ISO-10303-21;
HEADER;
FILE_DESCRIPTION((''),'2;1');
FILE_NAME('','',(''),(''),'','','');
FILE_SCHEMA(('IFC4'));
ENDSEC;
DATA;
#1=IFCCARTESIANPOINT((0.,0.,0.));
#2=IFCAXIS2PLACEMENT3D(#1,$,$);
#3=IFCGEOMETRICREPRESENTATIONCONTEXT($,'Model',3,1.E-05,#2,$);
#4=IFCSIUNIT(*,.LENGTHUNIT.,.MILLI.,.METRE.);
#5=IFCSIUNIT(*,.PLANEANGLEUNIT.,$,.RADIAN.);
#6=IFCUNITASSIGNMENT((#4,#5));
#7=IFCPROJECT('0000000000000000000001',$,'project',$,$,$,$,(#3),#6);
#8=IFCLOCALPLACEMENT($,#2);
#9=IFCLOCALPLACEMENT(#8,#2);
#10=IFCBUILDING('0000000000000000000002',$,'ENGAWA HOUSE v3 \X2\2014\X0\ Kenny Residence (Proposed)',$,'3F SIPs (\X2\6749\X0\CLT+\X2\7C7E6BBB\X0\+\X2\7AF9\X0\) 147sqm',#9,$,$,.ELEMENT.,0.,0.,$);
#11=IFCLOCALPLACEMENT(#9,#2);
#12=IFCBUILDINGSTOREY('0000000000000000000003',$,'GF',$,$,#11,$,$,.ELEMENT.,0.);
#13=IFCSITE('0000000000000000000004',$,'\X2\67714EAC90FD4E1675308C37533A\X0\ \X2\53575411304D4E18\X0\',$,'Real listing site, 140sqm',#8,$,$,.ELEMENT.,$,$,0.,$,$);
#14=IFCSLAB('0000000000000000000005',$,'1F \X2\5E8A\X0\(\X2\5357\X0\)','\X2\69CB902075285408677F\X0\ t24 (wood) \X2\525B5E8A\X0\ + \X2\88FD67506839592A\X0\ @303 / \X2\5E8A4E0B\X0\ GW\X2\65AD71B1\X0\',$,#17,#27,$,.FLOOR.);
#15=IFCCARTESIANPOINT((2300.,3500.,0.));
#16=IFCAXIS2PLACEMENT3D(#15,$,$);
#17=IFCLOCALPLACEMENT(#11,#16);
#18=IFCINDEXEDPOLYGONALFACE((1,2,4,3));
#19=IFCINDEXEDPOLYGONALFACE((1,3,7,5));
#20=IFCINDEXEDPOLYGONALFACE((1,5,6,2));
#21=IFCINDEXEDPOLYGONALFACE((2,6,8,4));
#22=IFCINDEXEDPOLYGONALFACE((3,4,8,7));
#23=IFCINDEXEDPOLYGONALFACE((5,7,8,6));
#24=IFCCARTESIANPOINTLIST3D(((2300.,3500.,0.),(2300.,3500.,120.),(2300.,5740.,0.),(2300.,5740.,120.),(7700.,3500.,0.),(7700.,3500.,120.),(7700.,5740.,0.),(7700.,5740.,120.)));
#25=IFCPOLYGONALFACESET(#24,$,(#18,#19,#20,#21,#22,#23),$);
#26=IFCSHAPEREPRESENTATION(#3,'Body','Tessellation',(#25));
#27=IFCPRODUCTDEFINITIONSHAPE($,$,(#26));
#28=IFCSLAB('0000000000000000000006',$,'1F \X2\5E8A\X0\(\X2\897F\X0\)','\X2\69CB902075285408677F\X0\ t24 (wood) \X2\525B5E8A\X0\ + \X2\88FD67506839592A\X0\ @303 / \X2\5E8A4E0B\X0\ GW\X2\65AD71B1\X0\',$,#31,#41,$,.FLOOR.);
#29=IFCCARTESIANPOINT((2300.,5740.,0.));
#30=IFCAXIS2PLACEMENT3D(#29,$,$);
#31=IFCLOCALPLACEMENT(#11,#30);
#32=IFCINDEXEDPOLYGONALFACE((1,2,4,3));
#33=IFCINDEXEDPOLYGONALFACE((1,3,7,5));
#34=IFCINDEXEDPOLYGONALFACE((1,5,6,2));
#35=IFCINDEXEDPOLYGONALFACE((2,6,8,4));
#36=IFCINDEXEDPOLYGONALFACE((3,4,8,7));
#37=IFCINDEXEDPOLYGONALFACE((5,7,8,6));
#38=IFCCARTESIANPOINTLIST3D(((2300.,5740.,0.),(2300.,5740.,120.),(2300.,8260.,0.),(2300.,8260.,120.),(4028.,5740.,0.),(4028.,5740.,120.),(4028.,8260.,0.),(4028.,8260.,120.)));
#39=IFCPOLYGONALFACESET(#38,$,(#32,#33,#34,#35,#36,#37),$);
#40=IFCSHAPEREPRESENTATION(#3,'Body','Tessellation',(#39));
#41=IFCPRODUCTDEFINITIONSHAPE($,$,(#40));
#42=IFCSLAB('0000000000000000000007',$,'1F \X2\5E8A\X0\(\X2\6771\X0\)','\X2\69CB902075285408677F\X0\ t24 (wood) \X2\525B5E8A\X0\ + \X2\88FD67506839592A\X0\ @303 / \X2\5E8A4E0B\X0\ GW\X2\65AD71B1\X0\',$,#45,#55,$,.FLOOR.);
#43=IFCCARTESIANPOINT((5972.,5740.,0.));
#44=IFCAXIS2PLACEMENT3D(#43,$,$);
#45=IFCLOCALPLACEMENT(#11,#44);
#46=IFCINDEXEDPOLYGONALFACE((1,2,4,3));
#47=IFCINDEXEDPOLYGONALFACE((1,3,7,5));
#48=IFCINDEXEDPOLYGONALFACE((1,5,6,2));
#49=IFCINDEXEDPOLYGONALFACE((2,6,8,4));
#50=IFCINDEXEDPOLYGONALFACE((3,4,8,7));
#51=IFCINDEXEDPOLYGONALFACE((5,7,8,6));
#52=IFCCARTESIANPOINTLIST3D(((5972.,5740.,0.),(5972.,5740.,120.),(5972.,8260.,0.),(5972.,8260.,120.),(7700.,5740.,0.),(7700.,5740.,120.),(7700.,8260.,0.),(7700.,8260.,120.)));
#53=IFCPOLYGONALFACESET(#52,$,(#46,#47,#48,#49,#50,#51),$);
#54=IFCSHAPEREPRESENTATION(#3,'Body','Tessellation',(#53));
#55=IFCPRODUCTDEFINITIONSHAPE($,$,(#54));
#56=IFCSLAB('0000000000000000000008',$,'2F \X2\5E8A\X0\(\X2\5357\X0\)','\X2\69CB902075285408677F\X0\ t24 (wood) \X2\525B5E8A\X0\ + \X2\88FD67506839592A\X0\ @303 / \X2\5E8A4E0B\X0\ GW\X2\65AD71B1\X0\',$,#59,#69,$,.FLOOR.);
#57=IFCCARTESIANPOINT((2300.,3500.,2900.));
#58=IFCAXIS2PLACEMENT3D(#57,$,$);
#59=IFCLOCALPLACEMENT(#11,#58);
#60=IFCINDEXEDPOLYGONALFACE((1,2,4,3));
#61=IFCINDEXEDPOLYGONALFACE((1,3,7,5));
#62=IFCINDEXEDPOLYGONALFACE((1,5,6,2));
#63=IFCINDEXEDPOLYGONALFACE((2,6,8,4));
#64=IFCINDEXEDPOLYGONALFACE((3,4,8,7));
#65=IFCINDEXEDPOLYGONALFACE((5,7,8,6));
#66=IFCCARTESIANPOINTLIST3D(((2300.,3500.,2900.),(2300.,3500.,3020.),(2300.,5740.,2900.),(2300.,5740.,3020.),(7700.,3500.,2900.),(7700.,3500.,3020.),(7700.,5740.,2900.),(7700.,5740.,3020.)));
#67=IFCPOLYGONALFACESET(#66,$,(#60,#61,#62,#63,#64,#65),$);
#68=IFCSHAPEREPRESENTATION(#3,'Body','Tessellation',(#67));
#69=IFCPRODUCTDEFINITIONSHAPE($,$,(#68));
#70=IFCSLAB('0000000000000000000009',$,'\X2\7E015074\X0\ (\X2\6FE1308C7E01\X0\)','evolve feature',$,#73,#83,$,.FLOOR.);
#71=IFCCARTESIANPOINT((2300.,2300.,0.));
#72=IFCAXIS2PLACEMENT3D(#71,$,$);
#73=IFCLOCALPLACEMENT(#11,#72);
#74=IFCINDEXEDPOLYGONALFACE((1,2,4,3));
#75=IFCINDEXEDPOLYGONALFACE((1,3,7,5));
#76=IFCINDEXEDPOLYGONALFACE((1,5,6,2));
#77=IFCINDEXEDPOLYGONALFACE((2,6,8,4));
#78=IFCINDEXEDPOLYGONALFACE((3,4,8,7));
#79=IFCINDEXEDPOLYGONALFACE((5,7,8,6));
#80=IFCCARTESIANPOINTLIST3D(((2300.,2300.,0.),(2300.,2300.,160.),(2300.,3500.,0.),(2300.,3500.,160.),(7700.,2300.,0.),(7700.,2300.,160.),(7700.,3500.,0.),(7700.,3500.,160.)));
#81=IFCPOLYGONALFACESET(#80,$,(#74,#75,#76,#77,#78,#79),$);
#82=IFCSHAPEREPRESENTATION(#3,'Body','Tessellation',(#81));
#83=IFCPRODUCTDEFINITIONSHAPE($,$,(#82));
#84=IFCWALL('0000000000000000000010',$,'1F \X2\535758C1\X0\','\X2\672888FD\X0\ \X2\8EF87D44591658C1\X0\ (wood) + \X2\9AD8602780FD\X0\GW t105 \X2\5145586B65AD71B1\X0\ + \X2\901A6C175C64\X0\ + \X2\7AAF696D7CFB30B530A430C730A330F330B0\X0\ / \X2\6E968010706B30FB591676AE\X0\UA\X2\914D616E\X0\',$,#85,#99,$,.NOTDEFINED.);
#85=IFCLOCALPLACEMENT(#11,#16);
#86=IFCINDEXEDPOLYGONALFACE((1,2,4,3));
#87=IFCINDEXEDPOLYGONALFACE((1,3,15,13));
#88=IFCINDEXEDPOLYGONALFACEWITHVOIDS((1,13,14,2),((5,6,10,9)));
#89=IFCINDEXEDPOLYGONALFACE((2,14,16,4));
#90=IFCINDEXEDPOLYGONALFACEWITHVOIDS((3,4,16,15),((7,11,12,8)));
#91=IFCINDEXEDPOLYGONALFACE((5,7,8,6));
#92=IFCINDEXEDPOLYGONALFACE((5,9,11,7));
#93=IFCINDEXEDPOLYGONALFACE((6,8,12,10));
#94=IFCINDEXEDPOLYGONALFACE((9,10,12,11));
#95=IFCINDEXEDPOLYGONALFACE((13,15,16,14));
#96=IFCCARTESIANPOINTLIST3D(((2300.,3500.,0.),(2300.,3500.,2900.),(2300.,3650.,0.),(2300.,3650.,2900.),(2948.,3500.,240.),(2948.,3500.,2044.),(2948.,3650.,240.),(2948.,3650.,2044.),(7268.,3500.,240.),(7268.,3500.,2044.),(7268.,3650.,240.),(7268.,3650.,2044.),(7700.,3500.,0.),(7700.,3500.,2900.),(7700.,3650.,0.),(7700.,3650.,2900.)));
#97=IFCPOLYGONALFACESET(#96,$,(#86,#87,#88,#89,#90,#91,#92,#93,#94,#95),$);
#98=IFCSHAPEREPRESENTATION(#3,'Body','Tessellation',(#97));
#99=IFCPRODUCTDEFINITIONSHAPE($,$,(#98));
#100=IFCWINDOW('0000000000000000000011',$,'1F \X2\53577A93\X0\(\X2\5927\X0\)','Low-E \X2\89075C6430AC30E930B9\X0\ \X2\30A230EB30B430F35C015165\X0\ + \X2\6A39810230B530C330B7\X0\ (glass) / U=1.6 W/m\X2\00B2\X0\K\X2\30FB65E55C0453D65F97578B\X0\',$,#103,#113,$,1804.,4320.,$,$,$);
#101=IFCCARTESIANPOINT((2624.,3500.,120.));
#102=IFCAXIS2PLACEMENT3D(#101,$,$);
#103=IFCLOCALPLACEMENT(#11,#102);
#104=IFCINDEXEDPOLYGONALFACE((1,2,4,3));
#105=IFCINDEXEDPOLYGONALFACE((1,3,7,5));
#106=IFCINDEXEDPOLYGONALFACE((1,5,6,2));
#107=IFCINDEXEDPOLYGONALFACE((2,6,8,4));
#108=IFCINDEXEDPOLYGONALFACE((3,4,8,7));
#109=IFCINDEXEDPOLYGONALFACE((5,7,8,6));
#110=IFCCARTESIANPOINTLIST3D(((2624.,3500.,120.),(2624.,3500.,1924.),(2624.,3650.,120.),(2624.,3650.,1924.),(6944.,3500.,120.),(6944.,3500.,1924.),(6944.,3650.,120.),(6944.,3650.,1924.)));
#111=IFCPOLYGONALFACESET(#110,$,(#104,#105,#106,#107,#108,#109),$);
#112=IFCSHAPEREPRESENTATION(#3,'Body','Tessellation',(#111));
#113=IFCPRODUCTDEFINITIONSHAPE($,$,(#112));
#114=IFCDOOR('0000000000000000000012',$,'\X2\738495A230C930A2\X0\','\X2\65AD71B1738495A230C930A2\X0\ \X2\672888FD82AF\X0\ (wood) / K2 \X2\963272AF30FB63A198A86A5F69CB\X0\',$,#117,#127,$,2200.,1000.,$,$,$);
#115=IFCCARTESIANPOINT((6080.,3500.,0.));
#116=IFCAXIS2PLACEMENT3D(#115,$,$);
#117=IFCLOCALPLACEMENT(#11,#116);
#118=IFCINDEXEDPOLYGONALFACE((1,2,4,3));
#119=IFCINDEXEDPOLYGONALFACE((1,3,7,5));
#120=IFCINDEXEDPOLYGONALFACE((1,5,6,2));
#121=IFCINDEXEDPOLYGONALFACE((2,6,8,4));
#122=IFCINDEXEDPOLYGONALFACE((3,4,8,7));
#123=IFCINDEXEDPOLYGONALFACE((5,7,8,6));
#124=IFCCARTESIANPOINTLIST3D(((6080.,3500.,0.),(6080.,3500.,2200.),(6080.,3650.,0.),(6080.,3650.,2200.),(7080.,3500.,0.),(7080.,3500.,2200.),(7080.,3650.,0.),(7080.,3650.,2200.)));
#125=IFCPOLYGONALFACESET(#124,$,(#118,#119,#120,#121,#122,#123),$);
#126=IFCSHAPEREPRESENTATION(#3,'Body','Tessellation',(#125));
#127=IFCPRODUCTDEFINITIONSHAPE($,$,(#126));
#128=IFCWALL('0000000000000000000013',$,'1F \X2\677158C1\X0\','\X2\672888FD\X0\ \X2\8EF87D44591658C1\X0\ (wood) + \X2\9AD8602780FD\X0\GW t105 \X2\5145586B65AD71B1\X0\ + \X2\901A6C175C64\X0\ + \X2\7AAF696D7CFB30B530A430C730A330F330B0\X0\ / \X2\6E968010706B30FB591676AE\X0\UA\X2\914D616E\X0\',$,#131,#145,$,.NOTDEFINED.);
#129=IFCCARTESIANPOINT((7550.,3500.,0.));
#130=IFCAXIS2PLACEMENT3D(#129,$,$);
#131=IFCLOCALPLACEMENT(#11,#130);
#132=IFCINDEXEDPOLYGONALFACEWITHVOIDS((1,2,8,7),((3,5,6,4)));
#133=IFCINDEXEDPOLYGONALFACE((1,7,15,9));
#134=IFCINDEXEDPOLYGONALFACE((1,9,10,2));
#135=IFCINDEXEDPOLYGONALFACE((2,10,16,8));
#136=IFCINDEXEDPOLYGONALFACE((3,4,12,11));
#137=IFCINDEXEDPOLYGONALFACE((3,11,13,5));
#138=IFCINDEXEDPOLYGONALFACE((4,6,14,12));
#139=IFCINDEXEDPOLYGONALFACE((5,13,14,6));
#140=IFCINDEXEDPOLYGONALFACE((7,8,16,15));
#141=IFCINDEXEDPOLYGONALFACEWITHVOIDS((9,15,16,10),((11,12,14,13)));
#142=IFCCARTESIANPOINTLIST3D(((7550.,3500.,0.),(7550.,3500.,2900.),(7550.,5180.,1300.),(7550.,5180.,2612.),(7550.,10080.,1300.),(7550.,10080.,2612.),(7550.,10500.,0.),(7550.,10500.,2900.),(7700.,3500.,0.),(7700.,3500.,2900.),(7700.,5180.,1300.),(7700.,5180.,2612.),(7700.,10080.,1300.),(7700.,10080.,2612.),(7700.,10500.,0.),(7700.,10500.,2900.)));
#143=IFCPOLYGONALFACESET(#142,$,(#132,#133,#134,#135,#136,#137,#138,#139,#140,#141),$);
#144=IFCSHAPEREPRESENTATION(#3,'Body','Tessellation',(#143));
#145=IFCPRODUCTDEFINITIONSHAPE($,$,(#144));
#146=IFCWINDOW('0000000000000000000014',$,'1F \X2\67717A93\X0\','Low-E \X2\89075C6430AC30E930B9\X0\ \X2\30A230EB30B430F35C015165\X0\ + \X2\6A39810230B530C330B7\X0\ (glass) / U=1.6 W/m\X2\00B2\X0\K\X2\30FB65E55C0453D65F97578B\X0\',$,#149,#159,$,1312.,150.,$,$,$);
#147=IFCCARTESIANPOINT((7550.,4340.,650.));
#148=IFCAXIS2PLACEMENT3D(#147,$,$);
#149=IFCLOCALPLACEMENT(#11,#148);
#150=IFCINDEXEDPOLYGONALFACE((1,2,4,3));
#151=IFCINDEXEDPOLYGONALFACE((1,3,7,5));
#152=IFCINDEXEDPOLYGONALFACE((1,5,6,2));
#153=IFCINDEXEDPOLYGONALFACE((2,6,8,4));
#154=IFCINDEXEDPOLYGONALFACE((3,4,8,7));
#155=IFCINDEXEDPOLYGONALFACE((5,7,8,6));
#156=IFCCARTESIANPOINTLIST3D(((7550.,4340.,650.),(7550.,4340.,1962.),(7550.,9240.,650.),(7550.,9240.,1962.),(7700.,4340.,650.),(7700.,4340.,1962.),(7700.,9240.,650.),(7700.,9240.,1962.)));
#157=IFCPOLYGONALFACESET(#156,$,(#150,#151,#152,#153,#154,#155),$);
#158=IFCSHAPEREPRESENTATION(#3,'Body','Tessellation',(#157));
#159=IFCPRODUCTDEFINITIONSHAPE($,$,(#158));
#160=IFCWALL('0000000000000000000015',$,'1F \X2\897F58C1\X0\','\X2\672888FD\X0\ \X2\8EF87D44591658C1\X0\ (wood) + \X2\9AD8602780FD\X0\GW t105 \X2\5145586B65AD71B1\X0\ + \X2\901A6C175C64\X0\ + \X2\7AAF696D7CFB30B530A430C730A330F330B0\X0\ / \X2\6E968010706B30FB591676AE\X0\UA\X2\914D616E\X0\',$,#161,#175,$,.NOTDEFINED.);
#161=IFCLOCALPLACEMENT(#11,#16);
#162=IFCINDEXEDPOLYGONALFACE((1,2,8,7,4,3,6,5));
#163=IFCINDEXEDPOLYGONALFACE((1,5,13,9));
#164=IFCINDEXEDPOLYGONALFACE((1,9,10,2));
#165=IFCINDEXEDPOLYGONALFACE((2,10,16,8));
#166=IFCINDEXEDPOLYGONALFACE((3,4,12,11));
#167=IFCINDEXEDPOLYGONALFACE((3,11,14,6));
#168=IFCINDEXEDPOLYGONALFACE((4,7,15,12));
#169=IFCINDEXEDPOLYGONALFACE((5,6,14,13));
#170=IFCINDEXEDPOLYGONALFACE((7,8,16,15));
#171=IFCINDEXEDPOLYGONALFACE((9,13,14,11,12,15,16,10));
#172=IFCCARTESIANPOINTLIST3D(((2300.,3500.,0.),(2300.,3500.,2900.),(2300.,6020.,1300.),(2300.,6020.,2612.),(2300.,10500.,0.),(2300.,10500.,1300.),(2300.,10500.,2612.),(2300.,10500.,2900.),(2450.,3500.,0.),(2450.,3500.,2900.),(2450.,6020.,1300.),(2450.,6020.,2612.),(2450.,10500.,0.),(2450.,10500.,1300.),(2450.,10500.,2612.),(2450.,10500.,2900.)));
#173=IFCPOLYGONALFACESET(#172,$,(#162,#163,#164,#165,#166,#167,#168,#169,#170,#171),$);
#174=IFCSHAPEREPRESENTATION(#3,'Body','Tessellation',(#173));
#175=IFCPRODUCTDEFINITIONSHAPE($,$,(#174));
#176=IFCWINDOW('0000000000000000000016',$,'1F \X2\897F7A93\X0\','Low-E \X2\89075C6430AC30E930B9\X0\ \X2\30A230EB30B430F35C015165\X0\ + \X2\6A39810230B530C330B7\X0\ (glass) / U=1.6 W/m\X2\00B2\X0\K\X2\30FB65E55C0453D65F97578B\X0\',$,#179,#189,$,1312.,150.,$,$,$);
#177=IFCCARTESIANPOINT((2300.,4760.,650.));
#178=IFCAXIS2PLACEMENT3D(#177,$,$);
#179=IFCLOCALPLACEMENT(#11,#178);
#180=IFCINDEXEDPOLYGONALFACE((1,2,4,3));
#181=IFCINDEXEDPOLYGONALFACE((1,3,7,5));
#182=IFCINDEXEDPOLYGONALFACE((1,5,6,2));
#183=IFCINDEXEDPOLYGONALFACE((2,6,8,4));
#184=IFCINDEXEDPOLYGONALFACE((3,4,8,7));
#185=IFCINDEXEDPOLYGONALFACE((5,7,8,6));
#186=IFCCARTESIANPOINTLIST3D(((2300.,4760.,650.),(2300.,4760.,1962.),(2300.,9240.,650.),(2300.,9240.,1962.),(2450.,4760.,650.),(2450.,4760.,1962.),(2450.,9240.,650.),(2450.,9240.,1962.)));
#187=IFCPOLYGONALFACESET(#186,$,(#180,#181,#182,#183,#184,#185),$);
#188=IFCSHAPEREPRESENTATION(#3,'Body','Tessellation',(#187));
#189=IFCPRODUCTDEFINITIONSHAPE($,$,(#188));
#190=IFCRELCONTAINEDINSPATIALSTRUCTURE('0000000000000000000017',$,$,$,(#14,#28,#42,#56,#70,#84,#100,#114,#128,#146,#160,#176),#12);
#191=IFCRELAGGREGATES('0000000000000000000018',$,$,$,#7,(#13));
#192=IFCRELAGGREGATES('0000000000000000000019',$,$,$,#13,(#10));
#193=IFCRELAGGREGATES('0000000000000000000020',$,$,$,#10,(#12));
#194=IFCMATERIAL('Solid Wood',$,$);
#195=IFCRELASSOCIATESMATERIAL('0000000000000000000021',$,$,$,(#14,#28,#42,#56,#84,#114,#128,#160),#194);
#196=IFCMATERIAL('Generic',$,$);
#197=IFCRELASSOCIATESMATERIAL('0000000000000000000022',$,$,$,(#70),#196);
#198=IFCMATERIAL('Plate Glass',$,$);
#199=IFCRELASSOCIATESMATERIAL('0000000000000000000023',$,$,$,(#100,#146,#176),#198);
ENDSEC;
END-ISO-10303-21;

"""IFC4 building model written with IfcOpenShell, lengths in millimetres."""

from ifc_helpers import new_model, si_unit, frame, frame_2d, origin, place, context, project, spatial, rectangle, extrude, material, element, fill, save


model = new_model("IFC4")

# Units and contexts
model_context = context("Model", 3, precision=1e-05, world=origin())
ifc_project = project(units=[si_unit("LENGTHUNIT", "METRE", prefix="MILLI"), si_unit("PLANEANGLEUNIT", "RADIAN")], contexts=[model_context])

# Site, building, storey
site_placement = place(None, origin())
site = spatial("IfcSite", under=ifc_project, at=site_placement, Name="東京都世田谷区 南向き丘", ObjectType="Real listing site, 140sqm", CompositionType="ELEMENT", RefElevation=0.0)
building_placement = place(site_placement, origin())
building = spatial("IfcBuilding", under=site, at=building_placement, Name="ENGAWA HOUSE v3 — Kenny Residence (Proposed)", ObjectType="3F SIPs (杉CLT+籾殻+竹) 147sqm", CompositionType="ELEMENT", ElevationOfRefHeight=0.0, ElevationOfTerrain=0.0)
storey_placement = place(building_placement, origin())
storey = spatial("IfcBuildingStorey", under=building, at=storey_placement, Name="GF", CompositionType="ELEMENT", Elevation=0.0)

# Slabs
ifc_material_1 = material(Name="Solid Wood")
slab_1_placement = place(storey_placement, frame((2300.0, 3500.0, 0.0)))
element("IfcSlab", 1, at=slab_1_placement, inside=storey, material=ifc_material_1, Name="1F 床(南)", Description="構造用合板 t24 (wood) 剛床 + 製材根太 @303 / 床下 GW断熱", PredefinedType="FLOOR", context=model_context, shape_type="SweptSolid", body=[
    extrude(rectangle(XDim=5400.0, YDim=2240.0, at=frame_2d((2700.0, 1120.0))), frame((2300.0, 3500.0, 0.0)), (0.0, 0.0, 1.0), 120.0),
])
slab_2_placement = place(storey_placement, frame((2300.0, 5740.0, 0.0)))
element("IfcSlab", 2, at=slab_2_placement, inside=storey, material=ifc_material_1, Name="1F 床(西)", Description="構造用合板 t24 (wood) 剛床 + 製材根太 @303 / 床下 GW断熱", PredefinedType="FLOOR", context=model_context, shape_type="SweptSolid", body=[
    extrude(rectangle(XDim=1728.0, YDim=2520.0, at=frame_2d((864.0, 1260.0))), frame((2300.0, 5740.0, 0.0)), (0.0, 0.0, 1.0), 120.0),
])
slab_3_placement = place(storey_placement, frame((5972.0, 5740.0, 0.0)))
element("IfcSlab", 3, at=slab_3_placement, inside=storey, material=ifc_material_1, Name="1F 床(東)", Description="構造用合板 t24 (wood) 剛床 + 製材根太 @303 / 床下 GW断熱", PredefinedType="FLOOR", context=model_context, shape_type="SweptSolid", body=[
    extrude(rectangle(XDim=1728.0, YDim=2520.0, at=frame_2d((864.0, 1260.0))), frame((5972.0, 5740.0, 0.0)), (0.0, 0.0, 1.0), 120.0),
])
slab_4_placement = place(storey_placement, frame((2300.0, 3500.0, 2900.0)))
element("IfcSlab", 4, at=slab_4_placement, inside=storey, material=ifc_material_1, Name="2F 床(南)", Description="構造用合板 t24 (wood) 剛床 + 製材根太 @303 / 床下 GW断熱", PredefinedType="FLOOR", context=model_context, shape_type="SweptSolid", body=[
    extrude(rectangle(XDim=5400.0, YDim=2240.0, at=frame_2d((2700.0, 1120.0))), frame((2300.0, 3500.0, 2900.0)), (0.0, 0.0, 1.0), 120.0),
])
ifc_material_2 = material(Name="Generic")
slab_5_placement = place(storey_placement, frame((2300.0, 2300.0, 0.0)))
element("IfcSlab", 5, at=slab_5_placement, inside=storey, material=ifc_material_2, Name="縁側 (濡れ縁)", Description="evolve feature", PredefinedType="FLOOR", context=model_context, shape_type="SweptSolid", body=[
    extrude(rectangle(XDim=5400.0, YDim=1200.0, at=frame_2d((2700.0, 600.0))), frame((2300.0, 2300.0, 0.0)), (0.0, 0.0, 1.0), 160.0),
])

# Wall, openings, window, door
wall_1_placement = place(storey_placement, frame((2300.0, 3500.0, 0.0)))
wall_1 = element("IfcWall", 6, at=wall_1_placement, inside=storey, material=ifc_material_1, Name="1F 南壁", Description="木製 軸組外壁 (wood) + 高性能GW t105 充填断熱 + 通気層 + 窯業系サイディング / 準耐火・外皮UA配慮", PredefinedType="NOTDEFINED", context=model_context, shape_type="SweptSolid", body=[
    extrude(rectangle(XDim=5400.0, YDim=150.0, at=frame_2d((2700.0, 75.0))), frame((2300.0, 3500.0, 0.0)), (0.0, 0.0, 1.0), 2900.0),
])
opening_1_placement = place(storey_placement, frame((2624.0, 3500.0, 120.0)))
opening_1 = element("IfcOpeningElement", 7, at=opening_1_placement, cuts=wall_1, PredefinedType="NOTDEFINED", context=model_context, shape_type="SweptSolid", body=[
    extrude(rectangle(XDim=4320.0, YDim=150.0, at=frame_2d((2160.0, 75.0))), frame((2624.0, 3500.0, 120.0)), (0.0, 0.0, 1.0), 1804.0),
])
opening_2_placement = place(storey_placement, frame((6080.0, 3500.0, 0.0)))
opening_2 = element("IfcOpeningElement", 8, at=opening_2_placement, cuts=wall_1, PredefinedType="NOTDEFINED", context=model_context, shape_type="SweptSolid", body=[
    extrude(rectangle(XDim=1000.0, YDim=150.0, at=frame_2d((500.0, 75.0))), frame((6080.0, 3500.0, 0.0)), (0.0, 0.0, 1.0), 2200.0),
])
ifc_material_3 = material(Name="Plate Glass")
window_1_placement = place(storey_placement, frame((2624.0, 3500.0, 120.0)))
window_1 = element("IfcWindow", 9, at=window_1_placement, inside=storey, material=ifc_material_3, Name="1F 南窓(大)", Description="Low-E 複層ガラス アルゴン封入 + 樹脂サッシ (glass) / U=1.6 W/m²K・日射取得型", OverallHeight=1804.0, OverallWidth=4320.0, context=model_context, shape_type="SweptSolid", body=[
    extrude(rectangle(XDim=4320.0, YDim=150.0, at=frame_2d((2160.0, 75.0))), frame((2624.0, 3500.0, 120.0)), (0.0, 0.0, 1.0), 1804.0),
])
fill(opening_1, window_1)
door_placement = place(storey_placement, frame((6080.0, 3500.0, 0.0)))
door = element("IfcDoor", 10, at=door_placement, inside=storey, material=ifc_material_1, Name="玄関ドア", Description="断熱玄関ドア 木製芯 (wood) / K2 防犯・採風機構", OverallHeight=2200.0, OverallWidth=1000.0, context=model_context, shape_type="SweptSolid", body=[
    extrude(rectangle(XDim=1000.0, YDim=150.0, at=frame_2d((500.0, 75.0))), frame((6080.0, 3500.0, 0.0)), (0.0, 0.0, 1.0), 2200.0),
])
fill(opening_2, door)

# Walls, openings, windows
wall_2_placement = place(storey_placement, frame((7550.0, 3500.0, 0.0)))
wall_2 = element("IfcWall", 11, at=wall_2_placement, inside=storey, material=ifc_material_1, Name="1F 東壁", Description="木製 軸組外壁 (wood) + 高性能GW t105 充填断熱 + 通気層 + 窯業系サイディング / 準耐火・外皮UA配慮", PredefinedType="NOTDEFINED", context=model_context, shape_type="SweptSolid", body=[
    extrude(rectangle(XDim=150.0, YDim=7000.0, at=frame_2d((75.0, 3500.0))), frame((7550.0, 3500.0, 0.0)), (0.0, 0.0, 1.0), 2900.0),
])
opening_3_placement = place(storey_placement, frame((7550.0, 4340.0, 650.0)))
opening_3 = element("IfcOpeningElement", 12, at=opening_3_placement, cuts=wall_2, PredefinedType="NOTDEFINED", context=model_context, shape_type="SweptSolid", body=[
    extrude(rectangle(XDim=150.0, YDim=4900.0, at=frame_2d((75.0, 2450.0))), frame((7550.0, 4340.0, 650.0)), (0.0, 0.0, 1.0), 1312.0),
])
window_2_placement = place(storey_placement, frame((7550.0, 4340.0, 650.0)))
window_2 = element("IfcWindow", 13, at=window_2_placement, inside=storey, material=ifc_material_3, Name="1F 東窓", Description="Low-E 複層ガラス アルゴン封入 + 樹脂サッシ (glass) / U=1.6 W/m²K・日射取得型", OverallHeight=1312.0, OverallWidth=150.0, context=model_context, shape_type="SweptSolid", body=[
    extrude(rectangle(XDim=150.0, YDim=4900.0, at=frame_2d((75.0, 2450.0))), frame((7550.0, 4340.0, 650.0)), (0.0, 0.0, 1.0), 1312.0),
])
fill(opening_3, window_2)
wall_3_placement = place(storey_placement, frame((2300.0, 3500.0, 0.0)))
wall_3 = element("IfcWall", 14, at=wall_3_placement, inside=storey, material=ifc_material_1, Name="1F 西壁", Description="木製 軸組外壁 (wood) + 高性能GW t105 充填断熱 + 通気層 + 窯業系サイディング / 準耐火・外皮UA配慮", PredefinedType="NOTDEFINED", context=model_context, shape_type="SweptSolid", body=[
    extrude(rectangle(XDim=150.0, YDim=7000.0, at=frame_2d((75.0, 3500.0))), frame((2300.0, 3500.0, 0.0)), (0.0, 0.0, 1.0), 2900.0),
])
opening_4_placement = place(storey_placement, frame((2300.0, 4760.0, 650.0)))
opening_4 = element("IfcOpeningElement", 15, at=opening_4_placement, cuts=wall_3, PredefinedType="NOTDEFINED", context=model_context, shape_type="SweptSolid", body=[
    extrude(rectangle(XDim=150.0, YDim=4480.0, at=frame_2d((75.0, 2240.0))), frame((2300.0, 4760.0, 650.0)), (0.0, 0.0, 1.0), 1312.0),
])
window_3_placement = place(storey_placement, frame((2300.0, 4760.0, 650.0)))
window_3 = element("IfcWindow", 16, at=window_3_placement, inside=storey, material=ifc_material_3, Name="1F 西窓", Description="Low-E 複層ガラス アルゴン封入 + 樹脂サッシ (glass) / U=1.6 W/m²K・日射取得型", OverallHeight=1312.0, OverallWidth=150.0, context=model_context, shape_type="SweptSolid", body=[
    extrude(rectangle(XDim=150.0, YDim=4480.0, at=frame_2d((75.0, 2240.0))), frame((2300.0, 4760.0, 650.0)), (0.0, 0.0, 1.0), 1312.0),
])
fill(opening_4, window_3)

save(model, "model.ifc")
